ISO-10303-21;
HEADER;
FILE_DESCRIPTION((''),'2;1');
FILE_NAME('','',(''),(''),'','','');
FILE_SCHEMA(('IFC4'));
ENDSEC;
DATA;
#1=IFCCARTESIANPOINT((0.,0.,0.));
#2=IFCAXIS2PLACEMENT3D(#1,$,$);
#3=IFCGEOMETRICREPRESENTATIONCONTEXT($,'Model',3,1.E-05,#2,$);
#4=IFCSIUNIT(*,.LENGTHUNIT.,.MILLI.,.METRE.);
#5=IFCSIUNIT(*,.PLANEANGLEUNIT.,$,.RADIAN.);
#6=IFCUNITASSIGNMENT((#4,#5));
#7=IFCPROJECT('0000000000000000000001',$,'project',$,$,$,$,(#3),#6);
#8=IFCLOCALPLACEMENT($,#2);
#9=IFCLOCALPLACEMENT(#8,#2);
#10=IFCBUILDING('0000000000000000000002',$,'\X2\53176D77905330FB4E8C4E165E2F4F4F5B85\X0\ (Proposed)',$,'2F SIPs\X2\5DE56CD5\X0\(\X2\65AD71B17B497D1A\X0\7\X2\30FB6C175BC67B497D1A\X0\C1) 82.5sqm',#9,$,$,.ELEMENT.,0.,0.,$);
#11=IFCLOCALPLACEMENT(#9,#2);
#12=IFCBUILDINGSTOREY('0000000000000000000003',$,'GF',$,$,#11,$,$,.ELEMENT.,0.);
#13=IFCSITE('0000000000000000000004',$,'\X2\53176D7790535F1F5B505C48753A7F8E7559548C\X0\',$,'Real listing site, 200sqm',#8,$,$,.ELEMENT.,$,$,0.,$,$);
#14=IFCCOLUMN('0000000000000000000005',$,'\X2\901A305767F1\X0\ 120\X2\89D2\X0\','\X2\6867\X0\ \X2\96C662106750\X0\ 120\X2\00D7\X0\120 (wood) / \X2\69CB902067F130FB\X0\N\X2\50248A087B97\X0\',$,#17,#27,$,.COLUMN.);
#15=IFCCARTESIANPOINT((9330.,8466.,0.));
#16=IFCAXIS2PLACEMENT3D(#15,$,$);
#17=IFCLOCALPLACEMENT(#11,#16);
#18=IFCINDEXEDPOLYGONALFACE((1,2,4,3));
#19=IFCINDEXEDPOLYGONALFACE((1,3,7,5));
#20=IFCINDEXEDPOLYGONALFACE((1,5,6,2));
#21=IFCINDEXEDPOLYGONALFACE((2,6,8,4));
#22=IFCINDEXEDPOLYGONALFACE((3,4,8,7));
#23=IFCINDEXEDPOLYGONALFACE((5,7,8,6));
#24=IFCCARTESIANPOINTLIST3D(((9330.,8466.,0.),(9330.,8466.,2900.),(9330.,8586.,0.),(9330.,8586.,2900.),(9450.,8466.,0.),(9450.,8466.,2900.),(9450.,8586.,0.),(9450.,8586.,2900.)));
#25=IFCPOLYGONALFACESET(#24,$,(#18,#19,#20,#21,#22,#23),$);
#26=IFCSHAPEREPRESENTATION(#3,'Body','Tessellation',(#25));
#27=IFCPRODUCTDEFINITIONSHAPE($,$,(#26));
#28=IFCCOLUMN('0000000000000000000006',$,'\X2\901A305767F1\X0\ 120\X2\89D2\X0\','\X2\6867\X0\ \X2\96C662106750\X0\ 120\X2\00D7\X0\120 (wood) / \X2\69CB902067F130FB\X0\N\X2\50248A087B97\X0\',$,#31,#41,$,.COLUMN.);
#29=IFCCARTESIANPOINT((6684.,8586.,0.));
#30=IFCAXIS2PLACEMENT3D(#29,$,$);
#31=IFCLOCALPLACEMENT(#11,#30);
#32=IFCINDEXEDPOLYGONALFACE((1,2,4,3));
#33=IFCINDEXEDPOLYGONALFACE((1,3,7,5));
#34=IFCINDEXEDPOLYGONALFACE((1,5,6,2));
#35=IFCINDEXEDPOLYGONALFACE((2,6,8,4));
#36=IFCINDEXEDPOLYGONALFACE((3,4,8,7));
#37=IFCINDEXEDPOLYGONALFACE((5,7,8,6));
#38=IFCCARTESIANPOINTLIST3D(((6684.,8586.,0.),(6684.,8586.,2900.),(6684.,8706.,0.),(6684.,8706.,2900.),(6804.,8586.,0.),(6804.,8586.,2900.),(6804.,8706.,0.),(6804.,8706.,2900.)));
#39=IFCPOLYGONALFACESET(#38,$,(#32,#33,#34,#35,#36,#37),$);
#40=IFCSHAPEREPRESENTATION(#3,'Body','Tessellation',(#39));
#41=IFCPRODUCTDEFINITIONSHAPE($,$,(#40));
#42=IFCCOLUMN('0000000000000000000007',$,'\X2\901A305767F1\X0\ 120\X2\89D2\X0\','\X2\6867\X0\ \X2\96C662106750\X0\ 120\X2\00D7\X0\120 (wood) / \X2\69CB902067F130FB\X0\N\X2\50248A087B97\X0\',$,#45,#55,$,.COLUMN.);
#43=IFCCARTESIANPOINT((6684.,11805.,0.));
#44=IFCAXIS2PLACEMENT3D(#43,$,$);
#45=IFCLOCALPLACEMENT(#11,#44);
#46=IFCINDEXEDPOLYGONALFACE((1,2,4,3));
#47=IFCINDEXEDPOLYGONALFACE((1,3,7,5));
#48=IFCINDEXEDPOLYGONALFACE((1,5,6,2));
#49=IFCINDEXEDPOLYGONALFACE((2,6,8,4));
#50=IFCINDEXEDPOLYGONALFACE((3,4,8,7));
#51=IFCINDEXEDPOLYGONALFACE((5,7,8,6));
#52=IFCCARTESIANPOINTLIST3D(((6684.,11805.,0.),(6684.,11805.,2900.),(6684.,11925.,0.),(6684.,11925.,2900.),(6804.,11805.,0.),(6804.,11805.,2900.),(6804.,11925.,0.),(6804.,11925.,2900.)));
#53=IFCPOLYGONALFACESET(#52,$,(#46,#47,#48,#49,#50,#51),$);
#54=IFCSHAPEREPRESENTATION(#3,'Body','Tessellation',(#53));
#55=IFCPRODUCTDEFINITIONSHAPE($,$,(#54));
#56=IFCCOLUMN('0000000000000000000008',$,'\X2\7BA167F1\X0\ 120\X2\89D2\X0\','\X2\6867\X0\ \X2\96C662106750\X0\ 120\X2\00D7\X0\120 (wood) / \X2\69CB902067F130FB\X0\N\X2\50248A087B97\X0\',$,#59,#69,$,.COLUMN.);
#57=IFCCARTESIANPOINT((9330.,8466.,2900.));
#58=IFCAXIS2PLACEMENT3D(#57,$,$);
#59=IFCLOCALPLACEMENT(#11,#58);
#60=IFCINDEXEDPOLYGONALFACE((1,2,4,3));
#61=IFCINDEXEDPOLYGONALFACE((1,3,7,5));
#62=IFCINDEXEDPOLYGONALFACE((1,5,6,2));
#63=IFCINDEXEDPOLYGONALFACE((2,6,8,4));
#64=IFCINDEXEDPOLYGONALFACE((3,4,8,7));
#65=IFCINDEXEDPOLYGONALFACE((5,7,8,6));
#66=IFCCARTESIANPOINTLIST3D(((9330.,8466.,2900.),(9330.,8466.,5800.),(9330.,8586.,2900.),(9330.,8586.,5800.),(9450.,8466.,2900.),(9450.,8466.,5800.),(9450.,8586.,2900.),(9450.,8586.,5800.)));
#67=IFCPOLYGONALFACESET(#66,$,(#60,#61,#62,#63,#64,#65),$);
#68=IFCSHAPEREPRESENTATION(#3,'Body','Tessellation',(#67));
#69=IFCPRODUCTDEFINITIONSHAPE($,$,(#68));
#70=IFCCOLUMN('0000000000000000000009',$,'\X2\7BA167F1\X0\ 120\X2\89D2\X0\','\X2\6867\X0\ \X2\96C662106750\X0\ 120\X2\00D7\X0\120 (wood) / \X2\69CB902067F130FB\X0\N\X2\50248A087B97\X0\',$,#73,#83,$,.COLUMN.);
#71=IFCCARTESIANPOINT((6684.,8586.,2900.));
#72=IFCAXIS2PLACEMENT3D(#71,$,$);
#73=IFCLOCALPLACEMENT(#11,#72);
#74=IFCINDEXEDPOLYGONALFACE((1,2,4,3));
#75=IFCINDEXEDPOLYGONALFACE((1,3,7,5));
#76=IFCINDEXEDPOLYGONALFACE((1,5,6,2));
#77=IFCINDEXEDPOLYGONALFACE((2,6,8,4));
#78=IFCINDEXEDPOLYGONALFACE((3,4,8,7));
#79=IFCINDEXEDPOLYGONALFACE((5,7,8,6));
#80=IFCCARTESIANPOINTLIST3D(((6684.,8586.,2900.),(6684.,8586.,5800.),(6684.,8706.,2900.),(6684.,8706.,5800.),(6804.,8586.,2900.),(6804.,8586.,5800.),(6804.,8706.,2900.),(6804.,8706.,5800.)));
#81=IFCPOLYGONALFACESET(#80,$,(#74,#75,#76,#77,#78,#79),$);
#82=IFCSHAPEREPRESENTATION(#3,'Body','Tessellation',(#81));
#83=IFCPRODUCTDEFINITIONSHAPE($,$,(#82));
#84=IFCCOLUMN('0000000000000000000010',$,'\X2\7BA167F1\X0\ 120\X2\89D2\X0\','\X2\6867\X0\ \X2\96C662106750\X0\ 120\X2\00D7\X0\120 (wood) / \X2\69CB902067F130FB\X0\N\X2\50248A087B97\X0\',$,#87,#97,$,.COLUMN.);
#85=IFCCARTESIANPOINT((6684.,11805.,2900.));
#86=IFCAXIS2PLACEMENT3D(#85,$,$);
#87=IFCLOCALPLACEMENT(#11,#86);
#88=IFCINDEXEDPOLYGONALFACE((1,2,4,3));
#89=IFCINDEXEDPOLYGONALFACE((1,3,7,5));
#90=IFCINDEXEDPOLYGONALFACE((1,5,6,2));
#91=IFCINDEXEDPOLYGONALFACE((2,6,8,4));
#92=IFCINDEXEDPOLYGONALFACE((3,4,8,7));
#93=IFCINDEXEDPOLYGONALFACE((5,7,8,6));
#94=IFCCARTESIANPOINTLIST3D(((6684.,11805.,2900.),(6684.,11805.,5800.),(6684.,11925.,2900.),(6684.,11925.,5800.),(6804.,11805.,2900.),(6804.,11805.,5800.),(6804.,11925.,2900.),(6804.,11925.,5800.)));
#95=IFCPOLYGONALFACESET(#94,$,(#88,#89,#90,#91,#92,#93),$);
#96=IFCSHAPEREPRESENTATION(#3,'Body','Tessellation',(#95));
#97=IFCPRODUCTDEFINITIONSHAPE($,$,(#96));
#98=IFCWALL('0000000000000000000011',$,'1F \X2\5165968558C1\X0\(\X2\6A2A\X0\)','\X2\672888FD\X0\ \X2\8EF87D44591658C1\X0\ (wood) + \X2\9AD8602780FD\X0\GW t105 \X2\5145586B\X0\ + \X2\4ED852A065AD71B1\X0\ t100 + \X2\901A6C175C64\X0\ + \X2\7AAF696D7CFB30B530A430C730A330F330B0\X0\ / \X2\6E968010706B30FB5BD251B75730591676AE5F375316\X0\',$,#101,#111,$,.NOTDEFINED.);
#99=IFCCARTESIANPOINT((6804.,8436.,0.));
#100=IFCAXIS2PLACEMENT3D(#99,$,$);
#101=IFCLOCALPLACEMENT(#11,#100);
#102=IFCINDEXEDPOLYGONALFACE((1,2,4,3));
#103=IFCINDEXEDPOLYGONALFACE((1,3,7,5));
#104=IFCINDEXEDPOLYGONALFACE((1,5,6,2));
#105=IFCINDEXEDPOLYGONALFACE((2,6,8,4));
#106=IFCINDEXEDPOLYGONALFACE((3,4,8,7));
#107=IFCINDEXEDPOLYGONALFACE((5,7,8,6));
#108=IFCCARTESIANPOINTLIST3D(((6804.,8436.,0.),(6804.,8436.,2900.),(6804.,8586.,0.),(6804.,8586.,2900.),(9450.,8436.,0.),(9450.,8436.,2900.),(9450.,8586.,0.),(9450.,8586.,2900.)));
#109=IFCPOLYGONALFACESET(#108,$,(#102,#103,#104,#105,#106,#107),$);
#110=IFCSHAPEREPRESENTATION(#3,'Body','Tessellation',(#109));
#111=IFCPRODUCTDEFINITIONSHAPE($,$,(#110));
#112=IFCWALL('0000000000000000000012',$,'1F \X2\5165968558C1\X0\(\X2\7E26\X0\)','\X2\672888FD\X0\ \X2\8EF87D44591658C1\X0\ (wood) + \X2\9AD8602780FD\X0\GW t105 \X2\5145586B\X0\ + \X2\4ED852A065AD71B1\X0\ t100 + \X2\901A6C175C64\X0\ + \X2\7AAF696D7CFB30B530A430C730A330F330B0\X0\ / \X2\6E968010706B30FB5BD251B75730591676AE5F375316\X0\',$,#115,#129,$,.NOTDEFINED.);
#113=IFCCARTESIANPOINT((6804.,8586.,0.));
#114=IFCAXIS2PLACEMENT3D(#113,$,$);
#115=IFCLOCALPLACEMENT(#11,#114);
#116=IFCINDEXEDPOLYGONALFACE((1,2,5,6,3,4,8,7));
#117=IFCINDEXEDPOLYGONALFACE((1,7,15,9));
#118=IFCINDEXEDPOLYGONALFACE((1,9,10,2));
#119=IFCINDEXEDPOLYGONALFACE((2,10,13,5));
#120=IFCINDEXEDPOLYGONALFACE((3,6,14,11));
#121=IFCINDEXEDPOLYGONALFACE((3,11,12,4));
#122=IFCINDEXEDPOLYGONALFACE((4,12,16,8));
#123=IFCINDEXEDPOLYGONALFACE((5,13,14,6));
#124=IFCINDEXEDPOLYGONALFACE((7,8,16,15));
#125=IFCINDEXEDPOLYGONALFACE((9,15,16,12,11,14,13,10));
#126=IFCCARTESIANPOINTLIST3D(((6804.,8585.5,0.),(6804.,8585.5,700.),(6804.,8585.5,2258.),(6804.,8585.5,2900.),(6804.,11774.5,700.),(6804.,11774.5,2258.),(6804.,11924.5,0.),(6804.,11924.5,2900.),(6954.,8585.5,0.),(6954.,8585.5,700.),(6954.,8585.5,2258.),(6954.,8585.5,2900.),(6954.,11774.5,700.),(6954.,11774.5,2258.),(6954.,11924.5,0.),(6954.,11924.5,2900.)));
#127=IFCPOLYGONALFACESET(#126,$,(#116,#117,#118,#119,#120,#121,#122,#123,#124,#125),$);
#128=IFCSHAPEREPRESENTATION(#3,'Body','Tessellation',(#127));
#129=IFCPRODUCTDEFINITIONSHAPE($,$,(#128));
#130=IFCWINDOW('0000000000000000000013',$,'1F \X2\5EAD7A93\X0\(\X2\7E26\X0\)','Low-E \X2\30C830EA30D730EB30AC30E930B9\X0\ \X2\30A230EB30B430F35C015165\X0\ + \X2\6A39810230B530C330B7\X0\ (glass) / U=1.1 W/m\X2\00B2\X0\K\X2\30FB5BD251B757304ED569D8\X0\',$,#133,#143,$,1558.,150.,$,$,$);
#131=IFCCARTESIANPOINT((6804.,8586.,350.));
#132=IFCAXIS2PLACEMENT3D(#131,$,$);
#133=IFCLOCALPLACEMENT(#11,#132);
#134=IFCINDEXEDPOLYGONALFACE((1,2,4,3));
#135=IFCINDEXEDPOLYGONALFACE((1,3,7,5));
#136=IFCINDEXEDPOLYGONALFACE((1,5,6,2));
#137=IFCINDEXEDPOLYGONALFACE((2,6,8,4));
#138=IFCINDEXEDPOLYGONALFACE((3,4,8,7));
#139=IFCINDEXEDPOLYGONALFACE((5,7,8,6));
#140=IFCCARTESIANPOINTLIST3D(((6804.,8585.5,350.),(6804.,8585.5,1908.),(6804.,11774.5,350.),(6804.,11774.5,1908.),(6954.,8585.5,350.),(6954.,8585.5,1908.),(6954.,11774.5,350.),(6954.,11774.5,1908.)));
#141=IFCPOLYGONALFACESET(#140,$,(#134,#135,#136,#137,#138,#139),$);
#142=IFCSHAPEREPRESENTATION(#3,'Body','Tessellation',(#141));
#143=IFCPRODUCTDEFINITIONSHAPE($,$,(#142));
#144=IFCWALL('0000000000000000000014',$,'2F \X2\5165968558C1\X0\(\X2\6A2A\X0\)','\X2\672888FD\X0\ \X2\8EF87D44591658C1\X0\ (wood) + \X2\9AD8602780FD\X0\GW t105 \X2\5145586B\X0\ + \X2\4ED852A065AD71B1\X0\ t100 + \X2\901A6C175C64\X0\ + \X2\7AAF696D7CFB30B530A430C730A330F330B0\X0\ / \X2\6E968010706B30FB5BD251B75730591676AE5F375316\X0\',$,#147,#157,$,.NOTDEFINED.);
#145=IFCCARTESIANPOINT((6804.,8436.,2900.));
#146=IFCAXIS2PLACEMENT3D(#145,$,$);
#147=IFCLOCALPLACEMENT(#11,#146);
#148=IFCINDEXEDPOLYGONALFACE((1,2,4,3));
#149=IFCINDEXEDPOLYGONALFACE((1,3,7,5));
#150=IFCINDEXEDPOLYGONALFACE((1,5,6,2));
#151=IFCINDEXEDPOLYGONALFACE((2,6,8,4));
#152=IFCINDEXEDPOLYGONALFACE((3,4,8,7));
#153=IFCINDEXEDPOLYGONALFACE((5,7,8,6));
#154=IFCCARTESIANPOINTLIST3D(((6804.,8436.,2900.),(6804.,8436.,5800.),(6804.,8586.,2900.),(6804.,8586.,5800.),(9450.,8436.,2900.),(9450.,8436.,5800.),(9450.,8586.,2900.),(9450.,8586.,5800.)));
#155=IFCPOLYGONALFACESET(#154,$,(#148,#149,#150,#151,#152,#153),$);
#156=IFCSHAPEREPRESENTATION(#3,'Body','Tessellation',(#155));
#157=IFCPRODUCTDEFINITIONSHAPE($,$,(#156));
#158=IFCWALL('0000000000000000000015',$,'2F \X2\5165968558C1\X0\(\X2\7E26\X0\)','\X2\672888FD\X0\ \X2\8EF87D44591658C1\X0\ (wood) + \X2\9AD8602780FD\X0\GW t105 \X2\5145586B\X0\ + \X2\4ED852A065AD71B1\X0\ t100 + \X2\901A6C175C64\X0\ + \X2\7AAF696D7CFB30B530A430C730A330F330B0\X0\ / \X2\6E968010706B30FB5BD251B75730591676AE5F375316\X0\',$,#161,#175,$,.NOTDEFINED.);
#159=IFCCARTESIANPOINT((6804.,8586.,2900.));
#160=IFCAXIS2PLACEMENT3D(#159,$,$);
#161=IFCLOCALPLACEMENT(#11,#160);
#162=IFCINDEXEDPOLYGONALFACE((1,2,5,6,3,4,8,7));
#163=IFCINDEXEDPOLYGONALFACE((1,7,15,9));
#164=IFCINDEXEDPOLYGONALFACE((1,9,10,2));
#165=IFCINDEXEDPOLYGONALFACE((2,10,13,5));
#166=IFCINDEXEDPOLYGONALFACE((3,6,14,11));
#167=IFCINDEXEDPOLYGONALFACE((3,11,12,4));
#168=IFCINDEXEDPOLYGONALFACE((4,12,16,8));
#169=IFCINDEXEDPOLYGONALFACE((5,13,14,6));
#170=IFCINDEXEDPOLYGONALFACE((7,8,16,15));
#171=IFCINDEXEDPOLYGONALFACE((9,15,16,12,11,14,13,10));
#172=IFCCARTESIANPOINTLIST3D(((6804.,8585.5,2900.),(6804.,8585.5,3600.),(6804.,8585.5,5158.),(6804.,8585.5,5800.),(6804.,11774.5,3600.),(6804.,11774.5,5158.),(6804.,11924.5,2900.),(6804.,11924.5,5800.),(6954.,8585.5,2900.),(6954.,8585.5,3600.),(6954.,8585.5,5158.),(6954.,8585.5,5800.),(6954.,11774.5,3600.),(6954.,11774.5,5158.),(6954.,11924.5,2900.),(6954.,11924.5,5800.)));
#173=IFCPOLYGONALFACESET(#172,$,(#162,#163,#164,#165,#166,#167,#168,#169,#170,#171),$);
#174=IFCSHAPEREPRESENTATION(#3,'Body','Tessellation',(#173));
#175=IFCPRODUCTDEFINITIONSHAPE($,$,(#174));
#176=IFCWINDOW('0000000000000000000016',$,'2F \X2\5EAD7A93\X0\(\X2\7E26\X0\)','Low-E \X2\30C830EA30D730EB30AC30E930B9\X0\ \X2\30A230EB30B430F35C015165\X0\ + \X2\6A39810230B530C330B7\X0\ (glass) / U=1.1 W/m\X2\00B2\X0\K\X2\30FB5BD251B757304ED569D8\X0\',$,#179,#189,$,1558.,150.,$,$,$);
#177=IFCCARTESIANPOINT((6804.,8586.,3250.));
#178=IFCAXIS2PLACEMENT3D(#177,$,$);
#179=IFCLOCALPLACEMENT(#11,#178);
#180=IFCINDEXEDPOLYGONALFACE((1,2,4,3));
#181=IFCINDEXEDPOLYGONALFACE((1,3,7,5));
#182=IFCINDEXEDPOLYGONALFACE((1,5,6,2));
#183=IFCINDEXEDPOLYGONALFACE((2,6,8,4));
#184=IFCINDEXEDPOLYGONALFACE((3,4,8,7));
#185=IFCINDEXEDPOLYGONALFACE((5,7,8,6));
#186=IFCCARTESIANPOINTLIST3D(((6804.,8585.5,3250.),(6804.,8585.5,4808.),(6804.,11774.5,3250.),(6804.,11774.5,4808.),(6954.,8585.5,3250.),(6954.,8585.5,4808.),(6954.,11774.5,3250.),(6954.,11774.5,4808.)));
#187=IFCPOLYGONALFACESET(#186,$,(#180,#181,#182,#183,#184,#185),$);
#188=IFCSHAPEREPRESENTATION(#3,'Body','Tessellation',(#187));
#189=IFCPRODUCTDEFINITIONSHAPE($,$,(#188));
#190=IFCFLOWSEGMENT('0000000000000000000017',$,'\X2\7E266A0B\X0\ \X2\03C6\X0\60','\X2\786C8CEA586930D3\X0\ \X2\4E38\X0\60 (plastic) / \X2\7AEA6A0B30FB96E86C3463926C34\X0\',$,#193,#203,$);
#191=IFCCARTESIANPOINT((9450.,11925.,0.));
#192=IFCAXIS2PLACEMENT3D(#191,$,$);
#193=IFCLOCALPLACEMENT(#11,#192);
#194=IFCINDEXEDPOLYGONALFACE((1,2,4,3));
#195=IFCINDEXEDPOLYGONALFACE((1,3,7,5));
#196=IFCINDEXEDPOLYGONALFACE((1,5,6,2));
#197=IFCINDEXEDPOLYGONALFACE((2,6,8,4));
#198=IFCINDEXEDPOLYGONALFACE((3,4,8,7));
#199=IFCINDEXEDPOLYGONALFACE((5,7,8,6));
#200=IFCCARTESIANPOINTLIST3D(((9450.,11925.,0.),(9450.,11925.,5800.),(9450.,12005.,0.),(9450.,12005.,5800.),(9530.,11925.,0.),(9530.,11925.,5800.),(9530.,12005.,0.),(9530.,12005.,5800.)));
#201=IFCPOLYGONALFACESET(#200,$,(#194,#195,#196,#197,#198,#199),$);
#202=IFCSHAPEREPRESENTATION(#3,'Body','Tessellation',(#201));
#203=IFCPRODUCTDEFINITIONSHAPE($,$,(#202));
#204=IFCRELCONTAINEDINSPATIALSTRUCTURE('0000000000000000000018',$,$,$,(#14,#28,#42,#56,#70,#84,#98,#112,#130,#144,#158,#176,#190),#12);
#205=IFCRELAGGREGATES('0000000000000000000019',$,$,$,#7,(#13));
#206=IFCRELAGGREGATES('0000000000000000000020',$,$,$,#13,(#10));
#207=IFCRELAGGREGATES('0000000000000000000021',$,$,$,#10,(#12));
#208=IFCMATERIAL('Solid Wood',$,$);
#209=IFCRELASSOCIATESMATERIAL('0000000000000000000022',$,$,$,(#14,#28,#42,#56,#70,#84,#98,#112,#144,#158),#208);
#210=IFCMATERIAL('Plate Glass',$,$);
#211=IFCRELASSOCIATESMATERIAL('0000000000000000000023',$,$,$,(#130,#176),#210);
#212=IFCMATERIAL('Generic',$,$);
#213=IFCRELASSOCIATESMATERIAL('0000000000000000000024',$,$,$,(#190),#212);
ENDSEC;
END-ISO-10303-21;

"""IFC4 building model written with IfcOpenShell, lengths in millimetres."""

from ifc_helpers import new_model, si_unit, frame, frame_2d, origin, place, context, project, spatial, rectangle, extrude, material, element, fill, save


model = new_model("IFC4")

# Units and contexts
model_context = context("Model", 3, precision=1e-05, world=origin())
ifc_project = project(units=[si_unit("LENGTHUNIT", "METRE", prefix="MILLI"), si_unit("PLANEANGLEUNIT", "RADIAN")], contexts=[model_context])

# Site, building, storey
site_placement = place(None, origin())
site = spatial("IfcSite", under=ifc_project, at=site_placement, Name="北海道弟子屈町美留和", ObjectType="Real listing site, 200sqm", CompositionType="ELEMENT", RefElevation=0.0)
building_placement = place(site_placement, origin())
building = spatial("IfcBuilding", under=site, at=building_placement, Name="北海道・二世帯住宅 (Proposed)", ObjectType="2F SIPs工法(断熱等級7・気密等級C1) 82.5sqm", CompositionType="ELEMENT", ElevationOfRefHeight=0.0, ElevationOfTerrain=0.0)
storey_placement = place(building_placement, origin())
storey = spatial("IfcBuildingStorey", under=building, at=storey_placement, Name="GF", CompositionType="ELEMENT", Elevation=0.0)

# Columns
ifc_material_1 = material(Name="Solid Wood")
column_1_placement = place(storey_placement, frame((9330.0, 8466.0, 0.0)))
element("IfcColumn", 1, at=column_1_placement, inside=storey, material=ifc_material_1, Name="通し柱 120角", Description="桧 集成材 120×120 (wood) / 構造柱・N値計算", PredefinedType="COLUMN", context=model_context, shape_type="SweptSolid", body=[
    extrude(rectangle(XDim=120.0, YDim=120.0, at=frame_2d((60.0, 60.0))), frame((9330.0, 8466.0, 0.0)), (0.0, 0.0, 1.0), 2900.0),
])
column_2_placement = place(storey_placement, frame((6684.0, 8586.0, 0.0)))
element("IfcColumn", 2, at=column_2_placement, inside=storey, material=ifc_material_1, Name="通し柱 120角", Description="桧 集成材 120×120 (wood) / 構造柱・N値計算", PredefinedType="COLUMN", context=model_context, shape_type="SweptSolid", body=[
    extrude(rectangle(XDim=120.0, YDim=120.0, at=frame_2d((60.0, 60.0))), frame((6684.0, 8586.0, 0.0)), (0.0, 0.0, 1.0), 2900.0),
])
column_3_placement = place(storey_placement, frame((6684.0, 11805.0, 0.0)))
element("IfcColumn", 3, at=column_3_placement, inside=storey, material=ifc_material_1, Name="通し柱 120角", Description="桧 集成材 120×120 (wood) / 構造柱・N値計算", PredefinedType="COLUMN", context=model_context, shape_type="SweptSolid", body=[
    extrude(rectangle(XDim=120.0, YDim=120.0, at=frame_2d((60.0, 60.0))), frame((6684.0, 11805.0, 0.0)), (0.0, 0.0, 1.0), 2900.0),
])
column_4_placement = place(storey_placement, frame((9330.0, 8466.0, 2900.0)))
element("IfcColumn", 4, at=column_4_placement, inside=storey, material=ifc_material_1, Name="管柱 120角", Description="桧 集成材 120×120 (wood) / 構造柱・N値計算", PredefinedType="COLUMN", context=model_context, shape_type="SweptSolid", body=[
    extrude(rectangle(XDim=120.0, YDim=120.0, at=frame_2d((60.0, 60.0))), frame((9330.0, 8466.0, 2900.0)), (0.0, 0.0, 1.0), 2900.0),
])
column_5_placement = place(storey_placement, frame((6684.0, 8586.0, 2900.0)))
element("IfcColumn", 5, at=column_5_placement, inside=storey, material=ifc_material_1, Name="管柱 120角", Description="桧 集成材 120×120 (wood) / 構造柱・N値計算", PredefinedType="COLUMN", context=model_context, shape_type="SweptSolid", body=[
    extrude(rectangle(XDim=120.0, YDim=120.0, at=frame_2d((60.0, 60.0))), frame((6684.0, 8586.0, 2900.0)), (0.0, 0.0, 1.0), 2900.0),
])
column_6_placement = place(storey_placement, frame((6684.0, 11805.0, 2900.0)))
element("IfcColumn", 6, at=column_6_placement, inside=storey, material=ifc_material_1, Name="管柱 120角", Description="桧 集成材 120×120 (wood) / 構造柱・N値計算", PredefinedType="COLUMN", context=model_context, shape_type="SweptSolid", body=[
    extrude(rectangle(XDim=120.0, YDim=120.0, at=frame_2d((60.0, 60.0))), frame((6684.0, 11805.0, 2900.0)), (0.0, 0.0, 1.0), 2900.0),
])

# Wall
wall_1_placement = place(storey_placement, frame((6804.0, 8436.0, 0.0)))
element("IfcWall", 7, at=wall_1_placement, inside=storey, material=ifc_material_1, Name="1F 入隅壁(横)", Description="木製 軸組外壁 (wood) + 高性能GW t105 充填 + 付加断熱 t100 + 通気層 + 窯業系サイディング / 準耐火・寒冷地外皮強化", PredefinedType="NOTDEFINED", context=model_context, shape_type="SweptSolid", body=[
    extrude(rectangle(XDim=2646.0, YDim=150.0, at=frame_2d((1323.0, 75.0))), frame((6804.0, 8436.0, 0.0)), (0.0, 0.0, 1.0), 2900.0),
])

# Wall, opening, window
wall_2_placement = place(storey_placement, frame((6804.0, 8586.0, 0.0)))
wall_2 = element("IfcWall", 8, at=wall_2_placement, inside=storey, material=ifc_material_1, Name="1F 入隅壁(縦)", Description="木製 軸組外壁 (wood) + 高性能GW t105 充填 + 付加断熱 t100 + 通気層 + 窯業系サイディング / 準耐火・寒冷地外皮強化", PredefinedType="NOTDEFINED", context=model_context, shape_type="SweptSolid", body=[
    extrude(rectangle(XDim=150.0, YDim=3339.0, at=frame_2d((75.0, 1669.0))), frame((6804.0, 8586.0, 0.0)), (0.0, 0.0, 1.0), 2900.0),
])
opening_1_placement = place(storey_placement, frame((6804.0, 8586.0, 350.0)))
opening_1 = element("IfcOpeningElement", 9, at=opening_1_placement, cuts=wall_2, PredefinedType="NOTDEFINED", context=model_context, shape_type="SweptSolid", body=[
    extrude(rectangle(XDim=150.0, YDim=3189.0, at=frame_2d((75.0, 1594.0))), frame((6804.0, 8586.0, 350.0)), (0.0, 0.0, 1.0), 1558.0),
])
ifc_material_2 = material(Name="Plate Glass")
window_1_placement = place(storey_placement, frame((6804.0, 8586.0, 350.0)))
window_1 = element("IfcWindow", 10, at=window_1_placement, inside=storey, material=ifc_material_2, Name="1F 庭窓(縦)", Description="Low-E トリプルガラス アルゴン封入 + 樹脂サッシ (glass) / U=1.1 W/m²K・寒冷地仕様", OverallHeight=1558.0, OverallWidth=150.0, context=model_context, shape_type="SweptSolid", body=[
    extrude(rectangle(XDim=150.0, YDim=3189.0, at=frame_2d((75.0, 1594.0))), frame((6804.0, 8586.0, 350.0)), (0.0, 0.0, 1.0), 1558.0),
])
fill(opening_1, window_1)

# Wall
wall_3_placement = place(storey_placement, frame((6804.0, 8436.0, 2900.0)))
element("IfcWall", 11, at=wall_3_placement, inside=storey, material=ifc_material_1, Name="2F 入隅壁(横)", Description="木製 軸組外壁 (wood) + 高性能GW t105 充填 + 付加断熱 t100 + 通気層 + 窯業系サイディング / 準耐火・寒冷地外皮強化", PredefinedType="NOTDEFINED", context=model_context, shape_type="SweptSolid", body=[
    extrude(rectangle(XDim=2646.0, YDim=150.0, at=frame_2d((1323.0, 75.0))), frame((6804.0, 8436.0, 2900.0)), (0.0, 0.0, 1.0), 2900.0),
])

# Wall, opening, window
wall_4_placement = place(storey_placement, frame((6804.0, 8586.0, 2900.0)))
wall_4 = element("IfcWall", 12, at=wall_4_placement, inside=storey, material=ifc_material_1, Name="2F 入隅壁(縦)", Description="木製 軸組外壁 (wood) + 高性能GW t105 充填 + 付加断熱 t100 + 通気層 + 窯業系サイディング / 準耐火・寒冷地外皮強化", PredefinedType="NOTDEFINED", context=model_context, shape_type="SweptSolid", body=[
    extrude(rectangle(XDim=150.0, YDim=3339.0, at=frame_2d((75.0, 1669.0))), frame((6804.0, 8586.0, 2900.0)), (0.0, 0.0, 1.0), 2900.0),
])
opening_2_placement = place(storey_placement, frame((6804.0, 8586.0, 3250.0)))
opening_2 = element("IfcOpeningElement", 13, at=opening_2_placement, cuts=wall_4, PredefinedType="NOTDEFINED", context=model_context, shape_type="SweptSolid", body=[
    extrude(rectangle(XDim=150.0, YDim=3189.0, at=frame_2d((75.0, 1594.0))), frame((6804.0, 8586.0, 3250.0)), (0.0, 0.0, 1.0), 1558.0),
])
window_2_placement = place(storey_placement, frame((6804.0, 8586.0, 3250.0)))
window_2 = element("IfcWindow", 14, at=window_2_placement, inside=storey, material=ifc_material_2, Name="2F 庭窓(縦)", Description="Low-E トリプルガラス アルゴン封入 + 樹脂サッシ (glass) / U=1.1 W/m²K・寒冷地仕様", OverallHeight=1558.0, OverallWidth=150.0, context=model_context, shape_type="SweptSolid", body=[
    extrude(rectangle(XDim=150.0, YDim=3189.0, at=frame_2d((75.0, 1594.0))), frame((6804.0, 8586.0, 3250.0)), (0.0, 0.0, 1.0), 1558.0),
])
fill(opening_2, window_2)

# Flow segment
ifc_material_3 = material(Name="Generic")
flow_segment_placement = place(storey_placement, frame((9450.0, 11925.0, 0.0)))
element("IfcFlowSegment", 15, at=flow_segment_placement, inside=storey, material=ifc_material_3, Name="縦樋 φ60", Description="硬質塩ビ 丸60 (plastic) / 竪樋・雨水排水", context=model_context, shape_type="SweptSolid", body=[
    extrude(rectangle(XDim=80.0, YDim=80.0, at=frame_2d((40.0, 40.0))), frame((9450.0, 11925.0, 0.0)), (0.0, 0.0, 1.0), 5800.0),
])

save(model, "model.ifc")
